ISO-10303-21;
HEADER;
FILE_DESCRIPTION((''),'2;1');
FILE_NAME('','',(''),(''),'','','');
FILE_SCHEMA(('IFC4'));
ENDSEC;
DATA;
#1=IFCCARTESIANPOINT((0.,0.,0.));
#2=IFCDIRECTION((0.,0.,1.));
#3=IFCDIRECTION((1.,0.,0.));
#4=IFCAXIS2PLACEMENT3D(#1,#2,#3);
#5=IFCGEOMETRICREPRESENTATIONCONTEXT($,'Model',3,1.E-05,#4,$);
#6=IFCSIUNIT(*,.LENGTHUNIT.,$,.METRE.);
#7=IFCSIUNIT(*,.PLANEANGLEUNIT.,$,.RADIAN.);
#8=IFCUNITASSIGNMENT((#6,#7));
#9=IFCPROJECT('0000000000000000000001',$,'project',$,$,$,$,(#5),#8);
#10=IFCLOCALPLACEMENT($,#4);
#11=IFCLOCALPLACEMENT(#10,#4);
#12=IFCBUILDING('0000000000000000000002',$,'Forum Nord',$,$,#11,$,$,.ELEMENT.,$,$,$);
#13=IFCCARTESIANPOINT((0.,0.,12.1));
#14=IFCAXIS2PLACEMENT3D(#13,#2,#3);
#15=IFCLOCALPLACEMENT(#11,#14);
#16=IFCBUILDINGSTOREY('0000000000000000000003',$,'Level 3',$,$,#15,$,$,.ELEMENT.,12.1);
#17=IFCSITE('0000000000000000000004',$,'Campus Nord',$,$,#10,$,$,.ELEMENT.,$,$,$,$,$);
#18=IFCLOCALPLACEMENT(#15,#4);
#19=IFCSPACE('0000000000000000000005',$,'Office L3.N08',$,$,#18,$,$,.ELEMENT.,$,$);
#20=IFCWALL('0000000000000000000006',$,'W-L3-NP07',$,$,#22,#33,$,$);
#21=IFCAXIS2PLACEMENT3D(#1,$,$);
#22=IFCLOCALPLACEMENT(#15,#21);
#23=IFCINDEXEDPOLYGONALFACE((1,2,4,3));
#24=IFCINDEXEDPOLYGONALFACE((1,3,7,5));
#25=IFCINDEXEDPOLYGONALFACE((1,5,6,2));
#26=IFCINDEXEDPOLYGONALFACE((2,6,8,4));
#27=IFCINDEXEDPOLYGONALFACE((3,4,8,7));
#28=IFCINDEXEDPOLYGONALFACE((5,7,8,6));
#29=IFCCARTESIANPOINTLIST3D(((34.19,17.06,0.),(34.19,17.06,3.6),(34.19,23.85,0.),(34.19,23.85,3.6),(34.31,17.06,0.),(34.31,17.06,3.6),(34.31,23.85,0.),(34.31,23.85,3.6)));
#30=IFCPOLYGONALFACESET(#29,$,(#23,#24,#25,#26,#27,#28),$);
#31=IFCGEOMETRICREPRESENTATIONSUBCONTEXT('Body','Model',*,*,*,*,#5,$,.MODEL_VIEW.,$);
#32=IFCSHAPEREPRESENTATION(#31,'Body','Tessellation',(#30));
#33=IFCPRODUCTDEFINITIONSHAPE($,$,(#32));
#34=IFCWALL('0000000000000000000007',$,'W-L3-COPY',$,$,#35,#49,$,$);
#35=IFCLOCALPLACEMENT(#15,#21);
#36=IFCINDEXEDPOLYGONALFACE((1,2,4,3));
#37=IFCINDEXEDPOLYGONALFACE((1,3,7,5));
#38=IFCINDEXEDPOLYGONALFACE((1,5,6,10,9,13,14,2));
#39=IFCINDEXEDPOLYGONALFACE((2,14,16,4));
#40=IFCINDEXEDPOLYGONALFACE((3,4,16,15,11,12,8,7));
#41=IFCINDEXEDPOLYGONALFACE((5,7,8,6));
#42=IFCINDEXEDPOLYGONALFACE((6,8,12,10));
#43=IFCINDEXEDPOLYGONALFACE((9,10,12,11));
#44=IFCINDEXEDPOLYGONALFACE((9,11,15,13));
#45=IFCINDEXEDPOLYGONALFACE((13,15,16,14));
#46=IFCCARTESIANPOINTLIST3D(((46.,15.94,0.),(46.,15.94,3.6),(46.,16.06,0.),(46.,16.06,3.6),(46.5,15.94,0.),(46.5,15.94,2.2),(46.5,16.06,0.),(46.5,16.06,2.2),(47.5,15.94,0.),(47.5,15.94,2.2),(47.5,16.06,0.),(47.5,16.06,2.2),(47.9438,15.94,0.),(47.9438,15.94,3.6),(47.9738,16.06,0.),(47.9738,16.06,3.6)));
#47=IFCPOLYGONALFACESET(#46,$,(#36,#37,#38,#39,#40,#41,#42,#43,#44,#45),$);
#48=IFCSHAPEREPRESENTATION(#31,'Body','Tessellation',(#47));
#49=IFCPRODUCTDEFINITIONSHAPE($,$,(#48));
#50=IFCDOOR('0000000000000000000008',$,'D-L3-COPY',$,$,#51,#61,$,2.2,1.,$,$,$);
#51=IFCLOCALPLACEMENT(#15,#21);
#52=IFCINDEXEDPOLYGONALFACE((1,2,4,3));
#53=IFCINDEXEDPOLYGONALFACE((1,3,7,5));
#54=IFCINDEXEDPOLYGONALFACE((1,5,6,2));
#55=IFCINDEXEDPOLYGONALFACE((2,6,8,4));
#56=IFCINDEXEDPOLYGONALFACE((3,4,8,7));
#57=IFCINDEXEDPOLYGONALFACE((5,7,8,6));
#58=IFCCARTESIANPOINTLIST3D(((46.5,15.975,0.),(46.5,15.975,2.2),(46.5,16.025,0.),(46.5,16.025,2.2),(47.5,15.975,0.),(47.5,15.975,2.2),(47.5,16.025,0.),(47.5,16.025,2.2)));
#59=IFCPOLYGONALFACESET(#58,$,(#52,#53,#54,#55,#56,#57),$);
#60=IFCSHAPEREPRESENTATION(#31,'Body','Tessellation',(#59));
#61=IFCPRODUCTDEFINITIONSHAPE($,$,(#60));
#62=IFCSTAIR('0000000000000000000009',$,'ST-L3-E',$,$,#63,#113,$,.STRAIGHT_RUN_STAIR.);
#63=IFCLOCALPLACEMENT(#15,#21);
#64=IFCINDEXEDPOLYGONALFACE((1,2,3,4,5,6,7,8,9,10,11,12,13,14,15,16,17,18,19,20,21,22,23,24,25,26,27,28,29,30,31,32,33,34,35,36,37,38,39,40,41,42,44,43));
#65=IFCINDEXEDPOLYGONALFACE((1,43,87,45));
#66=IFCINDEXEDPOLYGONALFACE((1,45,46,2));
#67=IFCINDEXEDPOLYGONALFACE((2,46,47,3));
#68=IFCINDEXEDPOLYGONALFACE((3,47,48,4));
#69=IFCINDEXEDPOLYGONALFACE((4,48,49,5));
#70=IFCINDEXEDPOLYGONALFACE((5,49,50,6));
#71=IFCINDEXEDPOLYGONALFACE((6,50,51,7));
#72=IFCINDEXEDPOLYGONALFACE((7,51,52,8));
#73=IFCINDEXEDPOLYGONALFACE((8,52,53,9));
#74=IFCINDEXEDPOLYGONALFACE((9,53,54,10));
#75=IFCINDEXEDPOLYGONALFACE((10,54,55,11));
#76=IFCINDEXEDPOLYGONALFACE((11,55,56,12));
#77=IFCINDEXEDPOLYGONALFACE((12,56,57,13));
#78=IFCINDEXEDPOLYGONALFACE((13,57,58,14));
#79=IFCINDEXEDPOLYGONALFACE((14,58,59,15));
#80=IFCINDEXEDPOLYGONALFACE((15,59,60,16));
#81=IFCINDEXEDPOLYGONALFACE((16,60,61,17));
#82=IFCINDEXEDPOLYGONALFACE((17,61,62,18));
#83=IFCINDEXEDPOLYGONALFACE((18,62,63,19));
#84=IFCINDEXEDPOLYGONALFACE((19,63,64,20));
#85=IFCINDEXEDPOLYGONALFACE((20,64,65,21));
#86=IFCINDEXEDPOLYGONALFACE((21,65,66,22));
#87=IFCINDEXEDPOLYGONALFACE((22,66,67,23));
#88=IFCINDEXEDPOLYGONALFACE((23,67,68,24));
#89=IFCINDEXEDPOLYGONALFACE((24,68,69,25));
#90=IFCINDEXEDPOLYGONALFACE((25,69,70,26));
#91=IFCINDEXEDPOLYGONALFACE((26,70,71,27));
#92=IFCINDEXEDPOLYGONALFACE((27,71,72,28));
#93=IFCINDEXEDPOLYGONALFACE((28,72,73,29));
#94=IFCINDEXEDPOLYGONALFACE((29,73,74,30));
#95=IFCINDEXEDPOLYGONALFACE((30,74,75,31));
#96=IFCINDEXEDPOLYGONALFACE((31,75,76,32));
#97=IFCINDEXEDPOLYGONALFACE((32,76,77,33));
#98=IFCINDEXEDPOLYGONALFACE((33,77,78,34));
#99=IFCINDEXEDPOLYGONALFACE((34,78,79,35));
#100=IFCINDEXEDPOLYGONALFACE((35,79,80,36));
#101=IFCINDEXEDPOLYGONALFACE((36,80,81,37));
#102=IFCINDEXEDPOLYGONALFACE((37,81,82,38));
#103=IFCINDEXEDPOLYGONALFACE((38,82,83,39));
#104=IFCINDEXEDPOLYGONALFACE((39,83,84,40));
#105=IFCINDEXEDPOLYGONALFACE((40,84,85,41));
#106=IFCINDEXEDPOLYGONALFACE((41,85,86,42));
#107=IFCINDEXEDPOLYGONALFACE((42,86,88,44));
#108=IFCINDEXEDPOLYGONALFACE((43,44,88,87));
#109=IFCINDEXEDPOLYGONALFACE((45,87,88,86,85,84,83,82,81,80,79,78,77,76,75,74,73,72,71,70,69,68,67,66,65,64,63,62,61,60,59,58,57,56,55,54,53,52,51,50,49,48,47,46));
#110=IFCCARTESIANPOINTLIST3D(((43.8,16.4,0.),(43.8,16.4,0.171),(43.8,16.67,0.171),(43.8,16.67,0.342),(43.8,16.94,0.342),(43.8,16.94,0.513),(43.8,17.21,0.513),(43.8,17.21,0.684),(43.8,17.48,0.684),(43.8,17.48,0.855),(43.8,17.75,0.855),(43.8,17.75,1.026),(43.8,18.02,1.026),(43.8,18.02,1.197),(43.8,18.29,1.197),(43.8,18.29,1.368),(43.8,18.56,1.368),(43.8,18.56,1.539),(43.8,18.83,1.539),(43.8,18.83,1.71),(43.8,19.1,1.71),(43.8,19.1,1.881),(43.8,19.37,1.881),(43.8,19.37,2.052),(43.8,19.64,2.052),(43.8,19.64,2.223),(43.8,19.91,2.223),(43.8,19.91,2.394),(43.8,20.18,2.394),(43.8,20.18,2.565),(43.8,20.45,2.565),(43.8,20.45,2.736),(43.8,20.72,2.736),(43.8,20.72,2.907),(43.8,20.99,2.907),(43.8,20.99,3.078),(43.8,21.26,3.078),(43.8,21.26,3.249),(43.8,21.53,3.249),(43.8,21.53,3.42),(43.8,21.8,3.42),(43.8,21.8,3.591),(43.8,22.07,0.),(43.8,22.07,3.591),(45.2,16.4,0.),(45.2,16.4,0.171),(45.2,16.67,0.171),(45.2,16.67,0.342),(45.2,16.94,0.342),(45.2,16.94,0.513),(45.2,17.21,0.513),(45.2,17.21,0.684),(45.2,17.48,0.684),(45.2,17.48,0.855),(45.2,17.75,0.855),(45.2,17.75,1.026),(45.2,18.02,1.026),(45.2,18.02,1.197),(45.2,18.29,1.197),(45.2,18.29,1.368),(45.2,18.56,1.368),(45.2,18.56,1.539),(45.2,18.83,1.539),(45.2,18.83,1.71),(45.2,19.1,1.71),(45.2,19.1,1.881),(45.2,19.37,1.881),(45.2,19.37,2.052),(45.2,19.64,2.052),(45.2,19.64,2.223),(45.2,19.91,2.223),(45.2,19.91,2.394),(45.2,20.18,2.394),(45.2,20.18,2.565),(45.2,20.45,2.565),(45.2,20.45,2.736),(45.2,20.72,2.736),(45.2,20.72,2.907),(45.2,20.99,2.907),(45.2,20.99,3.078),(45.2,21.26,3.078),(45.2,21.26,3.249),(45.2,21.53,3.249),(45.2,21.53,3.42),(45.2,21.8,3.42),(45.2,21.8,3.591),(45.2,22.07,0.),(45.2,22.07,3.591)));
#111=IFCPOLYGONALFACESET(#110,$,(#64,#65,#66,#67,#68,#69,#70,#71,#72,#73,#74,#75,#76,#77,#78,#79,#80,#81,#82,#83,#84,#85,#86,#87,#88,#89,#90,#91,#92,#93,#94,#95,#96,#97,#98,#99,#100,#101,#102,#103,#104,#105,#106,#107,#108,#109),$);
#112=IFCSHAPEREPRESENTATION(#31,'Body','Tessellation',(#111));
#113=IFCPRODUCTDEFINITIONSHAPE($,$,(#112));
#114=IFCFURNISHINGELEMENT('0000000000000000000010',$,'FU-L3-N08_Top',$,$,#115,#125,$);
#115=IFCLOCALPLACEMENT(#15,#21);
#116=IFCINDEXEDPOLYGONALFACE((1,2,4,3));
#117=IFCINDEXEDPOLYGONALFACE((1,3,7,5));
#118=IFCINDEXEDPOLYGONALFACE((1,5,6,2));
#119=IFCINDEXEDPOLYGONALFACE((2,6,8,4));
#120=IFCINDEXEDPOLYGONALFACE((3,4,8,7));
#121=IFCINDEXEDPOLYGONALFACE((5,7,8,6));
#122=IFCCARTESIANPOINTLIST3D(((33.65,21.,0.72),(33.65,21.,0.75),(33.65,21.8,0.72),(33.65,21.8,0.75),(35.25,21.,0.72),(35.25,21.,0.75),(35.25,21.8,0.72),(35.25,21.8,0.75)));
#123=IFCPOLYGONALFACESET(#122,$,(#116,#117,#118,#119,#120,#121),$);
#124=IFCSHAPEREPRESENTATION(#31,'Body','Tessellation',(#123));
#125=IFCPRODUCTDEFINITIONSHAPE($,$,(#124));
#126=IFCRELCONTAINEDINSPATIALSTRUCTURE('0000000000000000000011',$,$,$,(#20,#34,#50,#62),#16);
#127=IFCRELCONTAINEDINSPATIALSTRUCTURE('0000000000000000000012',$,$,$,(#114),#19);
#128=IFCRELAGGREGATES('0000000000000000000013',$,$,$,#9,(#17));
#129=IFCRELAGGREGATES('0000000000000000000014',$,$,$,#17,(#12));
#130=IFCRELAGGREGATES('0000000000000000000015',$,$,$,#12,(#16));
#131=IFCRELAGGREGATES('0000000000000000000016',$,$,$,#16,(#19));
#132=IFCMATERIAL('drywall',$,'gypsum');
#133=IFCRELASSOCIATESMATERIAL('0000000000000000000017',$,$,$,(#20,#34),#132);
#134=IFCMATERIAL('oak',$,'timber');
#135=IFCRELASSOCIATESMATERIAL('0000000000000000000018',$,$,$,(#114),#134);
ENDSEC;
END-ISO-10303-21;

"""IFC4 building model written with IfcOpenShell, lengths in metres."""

from ifc_helpers import new_model, si_unit, frame, frame_2d, origin_with_axes, place, context, subcontext, project, spatial, polyline, rectangle, outline, extrude, material, element, fill, save


model = new_model("IFC4")

# Units and contexts
model_context = context("Model", 3, precision=1e-05, world=origin_with_axes())
body_context = subcontext(model_context, "Body", "Model", "MODEL_VIEW")
ifc_project = project(units=[si_unit("LENGTHUNIT", "METRE"), si_unit("PLANEANGLEUNIT", "RADIAN")], contexts=[model_context])

# Site, building, storey
site_placement = place(None, origin_with_axes())
site = spatial("IfcSite", under=ifc_project, at=site_placement, Name="Campus Nord", CompositionType="ELEMENT")
building_placement = place(site_placement, origin_with_axes())
building = spatial("IfcBuilding", under=site, at=building_placement, Name="Forum Nord", CompositionType="ELEMENT")
storey_placement = place(building_placement, frame((0.0, 0.0, 12.1), z_axis=(0.0, 0.0, 1.0), x_axis=(1.0, 0.0, 0.0)))
storey = spatial("IfcBuildingStorey", under=building, at=storey_placement, Name="Level 3", CompositionType="ELEMENT", Elevation=12.1)

# Wall
ifc_material_1 = material(Name="drywall", Category="gypsum")
wall_1_placement = place(storey_placement, frame((34.25, 17.0, 0.0), z_axis=(0.0, 0.0, 1.0), x_axis=(0.0, 1.0, 0.0)))
element("IfcWall", 1, at=wall_1_placement, inside=storey, material=ifc_material_1, Name="W-L3-NP07", context=body_context, shape_type="SweptSolid", body=[
    extrude(outline(polyline([(0.06, -0.06), (6.85, -0.06), (6.85, 0.06), (0.06, 0.06), (0.06, -0.06)])), origin_with_axes(), (0.0, 0.0, 1.0), 3.6),
])

# Wall, opening, door
wall_2_placement = place(storey_placement, frame((46.0, 16.0, 0.0), z_axis=(0.0, 0.0, 1.0), x_axis=(1.0, 0.0, 0.0)))
wall_2 = element("IfcWall", 2, at=wall_2_placement, inside=storey, material=ifc_material_1, Name="W-L3-COPY", context=body_context, shape_type="SweptSolid", body=[
    extrude(outline(polyline([(0.0, -0.06), (1.9438, -0.06), (1.9738, 0.06), (0.0, 0.06), (0.0, -0.06)])), origin_with_axes(), (0.0, 0.0, 1.0), 3.6),
])
opening_1_placement = place(storey_placement, frame((46.0, 16.0, 0.0), z_axis=(0.0, 0.0, 1.0), x_axis=(1.0, 0.0, 0.0)))
opening_1 = element("IfcOpeningElement", 3, at=opening_1_placement, cuts=wall_2, context=body_context, shape_type="SweptSolid", body=[
    extrude(rectangle(XDim=1.0, YDim=0.12, at=frame_2d((1.0, 0.0), x_axis=(1.0, 0.0))), origin_with_axes(), (0.0, 0.0, 1.0), 2.2),
])
door_1_placement = place(storey_placement, frame((46.0, 16.0, 0.0), z_axis=(0.0, 0.0, 1.0), x_axis=(1.0, 0.0, 0.0)))
door_1 = element("IfcDoor", 4, at=door_1_placement, inside=storey, Name="D-L3-COPY", OverallHeight=2.2, OverallWidth=1.0, context=body_context, shape_type="SweptSolid", body=[
    extrude(rectangle(XDim=1.0, YDim=0.05, at=frame_2d((1.0, 0.0), x_axis=(1.0, 0.0))), origin_with_axes(), (0.0, 0.0, 1.0), 2.2),
])
fill(opening_1, door_1)

# Stair
stair_placement = place(storey_placement, frame((43.8, 16.4, 0.0), z_axis=(0.0, 0.0, 1.0), x_axis=(1.0, 0.0, 0.0)))
element("IfcStair", 5, at=stair_placement, inside=storey, Name="ST-L3-E", PredefinedType="STRAIGHT_RUN_STAIR", context=body_context, shape_type="SweptSolid", body=[
    extrude(outline(polyline([(0.0, 0.0), (5.67, 0.0), (5.67, 3.591), (5.4, 3.591), (5.4, 3.42), (5.13, 3.42), (5.13, 3.249), (4.86, 3.249), (4.86, 3.078), (4.59, 3.078), (4.59, 2.907), (4.32, 2.907), (4.32, 2.736), (4.05, 2.736), (4.05, 2.565), (3.78, 2.565), (3.78, 2.394), (3.51, 2.394), (3.51, 2.223), (3.24, 2.223), (3.24, 2.052), (2.97, 2.052), (2.97, 1.881), (2.7, 1.881), (2.7, 1.71), (2.43, 1.71), (2.43, 1.539), (2.16, 1.539), (2.16, 1.368), (1.89, 1.368), (1.89, 1.197), (1.62, 1.197), (1.62, 1.026), (1.35, 1.026), (1.35, 0.855), (1.08, 0.855), (1.08, 0.684), (0.81, 0.684), (0.81, 0.513), (0.54, 0.513), (0.54, 0.342), (0.27, 0.342), (0.27, 0.171), (0.0, 0.171), (0.0, 0.0)])), frame((0.0, 0.0, 0.0), z_axis=(1.0, 0.0, 0.0), x_axis=(0.0, 1.0, 0.0)), (0.0, 0.0, 1.0), 1.4),
])

# Shared definitions
space_placement = place(storey_placement, origin_with_axes())
space = spatial("IfcSpace", under=storey, at=space_placement, Name="Office L3.N08", CompositionType="ELEMENT")

# Furnishing element
ifc_material_2 = material(Name="oak", Category="timber")
furnishing_1_placement = place(storey_placement, frame((35.25, 22.4, 0.0), z_axis=(0.0, 0.0, 1.0), x_axis=(-1.0, 0.0, 0.0)))
element("IfcFurnishingElement", 6, at=furnishing_1_placement, inside=space, material=ifc_material_2, Name="FU-L3-N08_Top", context=body_context, shape_type="SweptSolid", body=[
    extrude(rectangle(XDim=1.6, YDim=0.8, at=frame_2d((0.8, 1.0), x_axis=(1.0, 0.0))), frame((0.0, 0.0, 0.72), z_axis=(0.0, 0.0, 1.0), x_axis=(1.0, 0.0, 0.0)), (0.0, 0.0, 1.0), 0.03),
])

save(model, "model.ifc")
